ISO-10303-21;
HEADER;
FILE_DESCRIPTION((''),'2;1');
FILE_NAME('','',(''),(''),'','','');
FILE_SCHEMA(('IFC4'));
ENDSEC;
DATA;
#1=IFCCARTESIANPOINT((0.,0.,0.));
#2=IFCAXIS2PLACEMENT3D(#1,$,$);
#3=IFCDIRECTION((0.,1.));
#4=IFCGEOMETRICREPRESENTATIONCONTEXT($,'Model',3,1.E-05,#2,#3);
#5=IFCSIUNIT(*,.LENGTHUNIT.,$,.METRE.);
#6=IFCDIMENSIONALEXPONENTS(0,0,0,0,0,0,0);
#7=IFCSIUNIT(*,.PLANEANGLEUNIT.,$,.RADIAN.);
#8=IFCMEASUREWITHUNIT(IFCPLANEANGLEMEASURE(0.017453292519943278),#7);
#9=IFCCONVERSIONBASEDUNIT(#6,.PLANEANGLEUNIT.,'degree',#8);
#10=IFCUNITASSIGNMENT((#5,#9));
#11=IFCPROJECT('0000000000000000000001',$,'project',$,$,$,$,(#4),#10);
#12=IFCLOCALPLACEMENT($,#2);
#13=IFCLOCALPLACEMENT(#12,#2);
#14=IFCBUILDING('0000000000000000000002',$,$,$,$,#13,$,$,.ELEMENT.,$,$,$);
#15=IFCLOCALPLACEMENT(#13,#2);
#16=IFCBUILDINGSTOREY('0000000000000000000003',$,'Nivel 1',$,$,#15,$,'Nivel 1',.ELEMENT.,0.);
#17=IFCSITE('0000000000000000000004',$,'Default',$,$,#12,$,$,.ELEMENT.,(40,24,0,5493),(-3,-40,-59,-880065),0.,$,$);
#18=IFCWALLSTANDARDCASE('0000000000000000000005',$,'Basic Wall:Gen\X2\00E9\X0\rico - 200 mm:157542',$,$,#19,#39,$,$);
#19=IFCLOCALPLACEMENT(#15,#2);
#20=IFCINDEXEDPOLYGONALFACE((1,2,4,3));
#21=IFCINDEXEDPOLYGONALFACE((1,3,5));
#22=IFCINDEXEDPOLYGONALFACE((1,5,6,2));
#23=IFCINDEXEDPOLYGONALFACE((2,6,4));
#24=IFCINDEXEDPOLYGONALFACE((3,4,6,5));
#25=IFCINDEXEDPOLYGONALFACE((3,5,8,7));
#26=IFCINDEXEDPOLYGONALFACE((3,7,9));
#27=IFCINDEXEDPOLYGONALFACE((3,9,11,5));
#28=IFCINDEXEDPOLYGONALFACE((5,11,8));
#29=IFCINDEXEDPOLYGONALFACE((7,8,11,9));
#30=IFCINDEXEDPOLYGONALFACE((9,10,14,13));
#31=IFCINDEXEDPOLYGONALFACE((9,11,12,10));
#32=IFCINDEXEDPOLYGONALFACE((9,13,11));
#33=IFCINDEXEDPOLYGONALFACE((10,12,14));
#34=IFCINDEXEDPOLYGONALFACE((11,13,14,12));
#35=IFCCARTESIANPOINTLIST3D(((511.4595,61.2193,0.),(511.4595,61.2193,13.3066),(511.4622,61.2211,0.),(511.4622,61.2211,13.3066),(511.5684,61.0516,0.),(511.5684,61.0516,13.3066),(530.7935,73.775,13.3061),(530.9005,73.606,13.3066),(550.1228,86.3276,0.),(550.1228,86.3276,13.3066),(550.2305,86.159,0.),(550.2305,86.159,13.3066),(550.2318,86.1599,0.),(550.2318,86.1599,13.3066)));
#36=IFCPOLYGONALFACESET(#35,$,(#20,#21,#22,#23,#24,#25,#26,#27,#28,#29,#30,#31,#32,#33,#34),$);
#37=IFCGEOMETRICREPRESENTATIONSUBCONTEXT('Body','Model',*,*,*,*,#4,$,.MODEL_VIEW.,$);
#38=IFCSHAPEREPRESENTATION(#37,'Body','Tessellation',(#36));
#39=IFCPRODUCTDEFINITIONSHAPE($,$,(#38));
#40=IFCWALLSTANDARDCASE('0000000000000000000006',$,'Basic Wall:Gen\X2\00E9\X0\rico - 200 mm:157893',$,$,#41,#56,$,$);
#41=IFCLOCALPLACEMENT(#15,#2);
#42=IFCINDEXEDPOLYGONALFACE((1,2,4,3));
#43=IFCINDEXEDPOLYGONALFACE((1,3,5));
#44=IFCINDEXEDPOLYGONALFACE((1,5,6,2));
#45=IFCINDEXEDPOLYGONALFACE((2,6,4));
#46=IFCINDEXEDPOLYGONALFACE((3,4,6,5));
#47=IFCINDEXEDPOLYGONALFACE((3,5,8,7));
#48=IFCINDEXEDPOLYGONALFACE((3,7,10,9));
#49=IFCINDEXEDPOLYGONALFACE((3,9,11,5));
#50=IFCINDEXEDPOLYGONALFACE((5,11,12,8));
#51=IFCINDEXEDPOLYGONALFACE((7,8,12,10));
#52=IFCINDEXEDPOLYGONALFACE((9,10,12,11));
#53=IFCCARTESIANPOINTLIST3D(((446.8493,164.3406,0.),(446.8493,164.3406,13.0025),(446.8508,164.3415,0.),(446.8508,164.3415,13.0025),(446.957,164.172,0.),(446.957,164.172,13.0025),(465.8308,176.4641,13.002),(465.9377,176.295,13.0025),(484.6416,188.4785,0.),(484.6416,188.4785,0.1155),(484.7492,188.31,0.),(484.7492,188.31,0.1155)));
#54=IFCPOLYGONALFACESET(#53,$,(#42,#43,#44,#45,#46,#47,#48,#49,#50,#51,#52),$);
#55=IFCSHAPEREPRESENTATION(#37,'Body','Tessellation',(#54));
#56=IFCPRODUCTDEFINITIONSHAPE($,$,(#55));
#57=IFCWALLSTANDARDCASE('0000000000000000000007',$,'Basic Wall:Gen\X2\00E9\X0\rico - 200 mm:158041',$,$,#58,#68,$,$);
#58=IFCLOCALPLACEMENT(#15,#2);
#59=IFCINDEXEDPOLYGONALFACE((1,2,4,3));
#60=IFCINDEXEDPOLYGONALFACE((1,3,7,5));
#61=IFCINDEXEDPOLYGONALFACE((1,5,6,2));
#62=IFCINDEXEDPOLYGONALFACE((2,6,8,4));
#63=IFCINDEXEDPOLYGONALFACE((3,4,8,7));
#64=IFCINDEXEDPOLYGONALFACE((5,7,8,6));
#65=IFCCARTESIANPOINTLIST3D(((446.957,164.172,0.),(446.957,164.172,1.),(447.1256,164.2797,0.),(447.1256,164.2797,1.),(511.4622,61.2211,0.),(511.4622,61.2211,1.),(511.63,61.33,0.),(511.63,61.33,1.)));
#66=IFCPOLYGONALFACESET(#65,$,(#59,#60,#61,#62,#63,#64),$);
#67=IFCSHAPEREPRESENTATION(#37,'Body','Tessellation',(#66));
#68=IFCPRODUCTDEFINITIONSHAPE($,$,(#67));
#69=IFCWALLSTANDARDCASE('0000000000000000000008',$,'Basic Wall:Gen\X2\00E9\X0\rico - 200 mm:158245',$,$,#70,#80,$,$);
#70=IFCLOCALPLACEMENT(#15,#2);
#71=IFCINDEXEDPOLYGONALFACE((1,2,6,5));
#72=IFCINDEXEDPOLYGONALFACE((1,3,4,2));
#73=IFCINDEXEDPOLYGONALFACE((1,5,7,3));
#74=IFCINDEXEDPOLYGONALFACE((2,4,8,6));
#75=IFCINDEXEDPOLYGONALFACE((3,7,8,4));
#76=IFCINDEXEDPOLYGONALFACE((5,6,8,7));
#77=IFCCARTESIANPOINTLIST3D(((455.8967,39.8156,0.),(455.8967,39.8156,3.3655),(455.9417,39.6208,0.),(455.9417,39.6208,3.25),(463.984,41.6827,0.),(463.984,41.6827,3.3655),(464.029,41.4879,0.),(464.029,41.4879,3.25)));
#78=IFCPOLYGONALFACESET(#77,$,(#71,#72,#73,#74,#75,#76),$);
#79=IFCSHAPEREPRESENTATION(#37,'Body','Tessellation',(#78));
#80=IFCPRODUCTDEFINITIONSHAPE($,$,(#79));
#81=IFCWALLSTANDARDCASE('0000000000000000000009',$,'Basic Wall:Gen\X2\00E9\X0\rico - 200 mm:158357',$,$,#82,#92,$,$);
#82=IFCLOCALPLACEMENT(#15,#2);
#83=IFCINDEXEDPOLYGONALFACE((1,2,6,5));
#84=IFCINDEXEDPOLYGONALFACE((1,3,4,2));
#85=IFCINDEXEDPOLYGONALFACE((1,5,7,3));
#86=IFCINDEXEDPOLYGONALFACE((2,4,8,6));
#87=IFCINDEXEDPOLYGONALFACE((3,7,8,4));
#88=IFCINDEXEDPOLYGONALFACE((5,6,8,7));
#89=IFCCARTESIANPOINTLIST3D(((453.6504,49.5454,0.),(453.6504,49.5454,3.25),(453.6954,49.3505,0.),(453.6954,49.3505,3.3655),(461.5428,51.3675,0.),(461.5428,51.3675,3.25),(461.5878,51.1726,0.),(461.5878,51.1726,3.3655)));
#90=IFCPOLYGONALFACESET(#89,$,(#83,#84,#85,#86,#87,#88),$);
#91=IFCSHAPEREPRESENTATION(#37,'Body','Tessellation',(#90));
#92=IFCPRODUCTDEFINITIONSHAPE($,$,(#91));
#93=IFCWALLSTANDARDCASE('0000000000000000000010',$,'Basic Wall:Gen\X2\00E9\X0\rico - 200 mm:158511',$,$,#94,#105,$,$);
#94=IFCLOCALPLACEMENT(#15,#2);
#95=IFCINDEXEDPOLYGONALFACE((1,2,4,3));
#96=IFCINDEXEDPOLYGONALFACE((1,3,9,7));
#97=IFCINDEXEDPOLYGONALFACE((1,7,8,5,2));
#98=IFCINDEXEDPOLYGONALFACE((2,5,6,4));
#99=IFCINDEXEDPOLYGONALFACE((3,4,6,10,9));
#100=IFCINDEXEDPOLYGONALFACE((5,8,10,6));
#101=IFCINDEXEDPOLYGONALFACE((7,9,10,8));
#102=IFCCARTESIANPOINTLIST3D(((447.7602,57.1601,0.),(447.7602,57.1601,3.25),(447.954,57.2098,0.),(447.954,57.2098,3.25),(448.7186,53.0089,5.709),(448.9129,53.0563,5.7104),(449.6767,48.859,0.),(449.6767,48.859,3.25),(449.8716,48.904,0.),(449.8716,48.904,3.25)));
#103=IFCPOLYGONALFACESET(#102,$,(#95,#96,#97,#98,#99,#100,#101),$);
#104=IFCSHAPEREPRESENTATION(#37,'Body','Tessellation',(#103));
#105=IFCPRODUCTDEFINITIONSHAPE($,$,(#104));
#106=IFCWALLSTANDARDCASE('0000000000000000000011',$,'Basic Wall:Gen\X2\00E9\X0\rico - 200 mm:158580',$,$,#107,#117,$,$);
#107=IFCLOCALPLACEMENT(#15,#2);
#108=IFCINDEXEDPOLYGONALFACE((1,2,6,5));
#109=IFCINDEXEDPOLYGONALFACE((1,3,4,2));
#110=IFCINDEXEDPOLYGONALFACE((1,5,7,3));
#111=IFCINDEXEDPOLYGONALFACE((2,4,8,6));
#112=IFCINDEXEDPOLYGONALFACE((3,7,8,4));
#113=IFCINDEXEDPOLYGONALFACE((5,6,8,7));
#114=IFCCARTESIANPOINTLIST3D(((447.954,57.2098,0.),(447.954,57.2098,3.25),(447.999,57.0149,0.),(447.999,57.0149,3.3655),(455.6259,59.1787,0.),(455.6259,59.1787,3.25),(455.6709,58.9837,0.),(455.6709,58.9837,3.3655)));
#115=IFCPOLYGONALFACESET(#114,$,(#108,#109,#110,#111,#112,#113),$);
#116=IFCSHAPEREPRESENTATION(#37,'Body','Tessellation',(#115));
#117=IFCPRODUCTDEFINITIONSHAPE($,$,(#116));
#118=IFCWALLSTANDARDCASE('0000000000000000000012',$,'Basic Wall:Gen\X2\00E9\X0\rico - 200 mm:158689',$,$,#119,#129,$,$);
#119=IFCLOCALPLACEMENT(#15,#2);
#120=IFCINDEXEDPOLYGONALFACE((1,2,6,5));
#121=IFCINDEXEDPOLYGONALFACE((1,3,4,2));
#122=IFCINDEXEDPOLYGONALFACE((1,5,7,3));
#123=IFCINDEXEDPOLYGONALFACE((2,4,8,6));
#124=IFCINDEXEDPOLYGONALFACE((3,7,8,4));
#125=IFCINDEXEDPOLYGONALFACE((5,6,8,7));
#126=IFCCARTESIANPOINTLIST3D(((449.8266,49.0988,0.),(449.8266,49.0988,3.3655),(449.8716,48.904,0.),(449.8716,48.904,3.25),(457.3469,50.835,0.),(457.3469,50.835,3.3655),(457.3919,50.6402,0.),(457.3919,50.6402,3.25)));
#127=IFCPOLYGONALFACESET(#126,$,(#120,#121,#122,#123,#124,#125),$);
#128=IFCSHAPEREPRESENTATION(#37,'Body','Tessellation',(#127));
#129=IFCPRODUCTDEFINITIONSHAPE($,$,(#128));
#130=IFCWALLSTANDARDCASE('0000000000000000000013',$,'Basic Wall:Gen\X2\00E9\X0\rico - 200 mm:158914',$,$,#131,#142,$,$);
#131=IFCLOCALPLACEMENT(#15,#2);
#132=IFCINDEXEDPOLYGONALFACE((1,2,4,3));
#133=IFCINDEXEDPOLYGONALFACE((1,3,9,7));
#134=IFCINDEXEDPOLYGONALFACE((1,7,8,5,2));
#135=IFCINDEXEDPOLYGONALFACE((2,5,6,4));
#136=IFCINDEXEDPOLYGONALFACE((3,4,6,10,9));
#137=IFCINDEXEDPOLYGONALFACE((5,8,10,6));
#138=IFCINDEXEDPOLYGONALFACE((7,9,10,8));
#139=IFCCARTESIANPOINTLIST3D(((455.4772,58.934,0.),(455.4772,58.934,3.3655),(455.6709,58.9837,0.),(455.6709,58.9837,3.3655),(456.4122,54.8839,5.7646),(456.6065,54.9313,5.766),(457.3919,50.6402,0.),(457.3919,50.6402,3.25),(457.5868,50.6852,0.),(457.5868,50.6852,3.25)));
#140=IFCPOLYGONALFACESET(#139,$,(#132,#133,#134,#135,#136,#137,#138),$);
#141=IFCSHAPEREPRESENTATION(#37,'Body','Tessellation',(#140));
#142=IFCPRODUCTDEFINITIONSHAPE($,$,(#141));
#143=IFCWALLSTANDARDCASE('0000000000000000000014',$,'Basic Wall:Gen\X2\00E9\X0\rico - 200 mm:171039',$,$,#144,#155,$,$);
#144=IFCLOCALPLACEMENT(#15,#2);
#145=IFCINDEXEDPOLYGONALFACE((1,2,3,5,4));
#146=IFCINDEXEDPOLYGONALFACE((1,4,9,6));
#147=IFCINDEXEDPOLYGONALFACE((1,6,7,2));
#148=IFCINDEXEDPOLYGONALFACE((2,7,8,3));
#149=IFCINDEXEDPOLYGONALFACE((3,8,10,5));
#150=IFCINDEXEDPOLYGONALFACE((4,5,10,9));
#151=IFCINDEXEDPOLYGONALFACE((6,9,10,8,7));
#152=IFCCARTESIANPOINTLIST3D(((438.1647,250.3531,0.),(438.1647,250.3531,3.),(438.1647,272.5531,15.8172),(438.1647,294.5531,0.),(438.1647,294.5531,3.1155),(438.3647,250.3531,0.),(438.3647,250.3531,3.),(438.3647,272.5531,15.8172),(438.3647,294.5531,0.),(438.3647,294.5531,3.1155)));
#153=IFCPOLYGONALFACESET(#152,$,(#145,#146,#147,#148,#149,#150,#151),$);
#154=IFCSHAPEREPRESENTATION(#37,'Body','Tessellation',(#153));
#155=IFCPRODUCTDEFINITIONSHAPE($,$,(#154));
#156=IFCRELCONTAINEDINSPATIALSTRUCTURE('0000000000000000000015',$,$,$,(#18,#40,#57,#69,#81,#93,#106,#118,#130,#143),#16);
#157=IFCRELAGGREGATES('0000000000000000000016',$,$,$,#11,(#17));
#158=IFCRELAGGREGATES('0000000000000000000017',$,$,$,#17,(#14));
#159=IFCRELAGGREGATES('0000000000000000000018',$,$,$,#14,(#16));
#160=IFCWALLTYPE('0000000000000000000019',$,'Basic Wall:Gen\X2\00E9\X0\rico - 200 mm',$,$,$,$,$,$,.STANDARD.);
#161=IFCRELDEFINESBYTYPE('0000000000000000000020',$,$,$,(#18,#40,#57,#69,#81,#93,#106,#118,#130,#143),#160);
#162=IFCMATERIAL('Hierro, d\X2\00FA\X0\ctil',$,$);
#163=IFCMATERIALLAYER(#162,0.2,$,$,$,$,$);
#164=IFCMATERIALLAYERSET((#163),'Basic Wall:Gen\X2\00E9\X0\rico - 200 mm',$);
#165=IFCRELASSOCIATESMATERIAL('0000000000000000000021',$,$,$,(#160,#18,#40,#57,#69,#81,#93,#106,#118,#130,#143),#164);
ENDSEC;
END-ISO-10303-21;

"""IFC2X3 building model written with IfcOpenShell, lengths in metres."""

from ifc_helpers import new_model, entity, si_unit, converted_unit, direction, frame, frame_2d, origin, place, context, subcontext, project, spatial, polyline, rectangle, outline, extrude, clip, bounded_halfspace, material, layer, layer_set, layer_usage, type_object, element, save


model = new_model("IFC2X3")

# Units and contexts
model_context = context("Model", 3, precision=1e-05, world=origin(), true_north=direction((0.0, 1.0)))
body_context = subcontext(model_context, "Body", "Model", "MODEL_VIEW")
ifc_project = project(units=[si_unit("LENGTHUNIT", "METRE"), converted_unit("PLANEANGLEUNIT", "degree", entity("IfcPlaneAngleMeasure", 0.017453292519943278), si_unit("PLANEANGLEUNIT", "RADIAN"), dimensions=[0, 0, 0, 0, 0, 0, 0])], contexts=[model_context])

# Site, building, storey
site_placement = place(None, origin())
site = spatial("IfcSite", under=ifc_project, at=site_placement, Name="Default", CompositionType="ELEMENT", RefLatitude=(40, 24, 0, 5493), RefLongitude=(-3, -40, -59, -880065), RefElevation=0.0)
building_placement = place(site_placement, origin())
building = spatial("IfcBuilding", under=site, at=building_placement, CompositionType="ELEMENT")
storey_placement = place(building_placement, origin())
storey = spatial("IfcBuildingStorey", under=building, at=storey_placement, Name="Nivel 1", LongName="Nivel 1", CompositionType="ELEMENT", Elevation=0.0)

# Walls
ifc_material_1 = material(Name="Hierro, dúctil")
ifc_layer_1 = layer(ifc_material_1, 0.2)
ifc_layer_set_1 = layer_set([ifc_layer_1], Name="Basic Wall:Genérico - 200 mm")
ifc_layer_usage_1 = layer_usage(ifc_layer_set_1, "AXIS2", "NEGATIVE", 0.1)
wall_type = type_object("IfcWallType", Name="Basic Wall:Genérico - 200 mm", PredefinedType="STANDARD", material=ifc_layer_set_1)
wall_1_placement = place(storey_placement, frame((511.5139, 61.1354, 0.0), z_axis=(0.0, 0.0, 1.0), x_axis=(0.838671, 0.544639, 0.0)))
element("IfcWallStandardCase", 1, at=wall_1_placement, inside=storey, type_object=wall_type, material=ifc_layer_usage_1, Name="Basic Wall:Genérico - 200 mm:157542", context=body_context, shape_type="Clipping", body=[
    clip(clip(extrude(rectangle(XDim=46.1008, YDim=0.2, at=frame_2d((23.0504, 0.0), x_axis=(-1.0, 0.0))), origin(), (0.0, 0.0, 1.0), 13.3066), bounded_halfspace(frame((23.0508, -0.1, 13.3066), z_axis=(0.499986, -0.003784, 0.866025), x_axis=(0.007567, 0.999971, 0.0)), False, frame((23.0508, -0.1, 13.3066)), polyline([(0.0, 0.0), (23.0484, 0.0), (23.05, 0.2), (0.0024, 0.2), (0.0, 0.0)]))), bounded_halfspace(frame((0.0, -0.1, 0.0), z_axis=(-0.499934, 0.008118, 0.866025), x_axis=(-0.016236, -0.999868, 0.0)), False, frame((0.0, -0.1, 0.0)), polyline([(0.0, 0.0), (23.0508, 0.0), (23.0532, 0.2), (0.0032, 0.2), (0.0, 0.0)]))),
])
ifc_layer_usage_2 = layer_usage(ifc_layer_set_1, "AXIS2", "NEGATIVE", 0.1)
wall_2_placement = place(storey_placement, frame((484.6954, 188.3942, 0.0), z_axis=(0.0, 0.0, 1.0), x_axis=(-0.842768, -0.538277, 0.0)))
element("IfcWallStandardCase", 2, at=wall_2_placement, inside=storey, type_object=wall_type, material=ifc_layer_usage_2, Name="Basic Wall:Genérico - 200 mm:157893", context=body_context, shape_type="Clipping", body=[
    clip(clip(extrude(rectangle(XDim=44.843, YDim=0.2, at=frame_2d((22.4215, 0.0), x_axis=(-1.0, 0.0))), origin(), (0.0, 0.0, 1.0), 13.0025), bounded_halfspace(frame((0.0, -0.1, 0.1155), z_axis=(-0.5, 0.0, 0.866025), x_axis=(0.0, -1.0, 0.0)), False, frame((0.0, -0.1, 0.1155)), polyline([(0.0, 0.0), (22.3202, 0.0), (22.3211, 0.2), (0.0, 0.2), (0.0, 0.0)]))), bounded_halfspace(frame((22.3202, -0.1, 13.002), z_axis=(0.499981, -0.004335, 0.866025), x_axis=(0.008669, 0.999962, 0.0)), False, frame((22.3202, -0.1, 13.002)), polyline([(0.0, 0.0), (22.5211, 0.0), (22.5228, 0.2), (0.0009, 0.2), (0.0, 0.0)]))),
])
ifc_layer_usage_3 = layer_usage(ifc_layer_set_1, "AXIS2", "NEGATIVE", 0.1)
wall_3_placement = place(storey_placement, frame((447.0408, 164.2266, 0.0), z_axis=(0.0, 0.0, 1.0), x_axis=(0.530951, -0.847403, 0.0)))
element("IfcWallStandardCase", 3, at=wall_3_placement, inside=storey, type_object=wall_type, material=ifc_layer_usage_3, Name="Basic Wall:Genérico - 200 mm:158041", context=body_context, shape_type="SweptSolid", body=[
    extrude(outline(polyline([(121.4917, -0.1), (121.4885, 0.1), (0.0, 0.1), (0.0017, -0.1), (121.4917, -0.1)])), origin(), (0.0, 0.0, 1.0), 1.0),
])
ifc_layer_usage_4 = layer_usage(ifc_layer_set_1, "AXIS2", "NEGATIVE", 0.1)
wall_4_placement = place(storey_placement, frame((455.9192, 39.7182, 0.0), z_axis=(0.0, 0.0, 1.0), x_axis=(0.97437, 0.224951, 0.0)))
element("IfcWallStandardCase", 4, at=wall_4_placement, inside=storey, type_object=wall_type, material=ifc_layer_usage_4, Name="Basic Wall:Genérico - 200 mm:158245", context=body_context, shape_type="Clipping", body=[
    clip(extrude(rectangle(XDim=8.3, YDim=0.2, at=frame_2d((4.15, 0.0), x_axis=(-1.0, 0.0))), origin(), (0.0, 0.0, 1.0), 3.3655), bounded_halfspace(frame((0.0, -0.1, 3.25), z_axis=(0.0, -0.5, 0.866025), x_axis=(1.0, 0.0, 0.0)), False, frame((0.0, -0.1, 3.25)), polyline([(0.0, 0.0), (8.3, 0.0), (8.3, 0.2), (8.1, 0.2), (0.2, 0.2), (0.0, 0.2), (0.0, 0.0)]))),
])
ifc_layer_usage_5 = layer_usage(ifc_layer_set_1, "AXIS2", "NEGATIVE", 0.1)
wall_5_placement = place(storey_placement, frame((461.5653, 51.27, 0.0), z_axis=(0.0, 0.0, 1.0), x_axis=(-0.97437, -0.224951, 0.0)))
element("IfcWallStandardCase", 5, at=wall_5_placement, inside=storey, type_object=wall_type, material=ifc_layer_usage_5, Name="Basic Wall:Genérico - 200 mm:158357", context=body_context, shape_type="Clipping", body=[
    clip(extrude(rectangle(XDim=8.1, YDim=0.2, at=frame_2d((4.05, 0.0), x_axis=(-1.0, 0.0))), origin(), (0.0, 0.0, 1.0), 3.3655), bounded_halfspace(frame((0.0, -0.1, 3.25), z_axis=(0.0, -0.5, 0.866025), x_axis=(1.0, 0.0, 0.0)), False, frame((0.0, -0.1, 3.25)), polyline([(0.0, 0.0), (8.1, 0.0), (8.1, 0.2), (7.9, 0.2), (0.0, 0.2), (0.0, 0.0)]))),
])
ifc_layer_usage_6 = layer_usage(ifc_layer_set_1, "AXIS2", "NEGATIVE", 0.1)
wall_6_placement = place(storey_placement, frame((449.7741, 48.8815, 0.0), z_axis=(0.0, 0.0, 1.0), x_axis=(-0.224951, 0.97437, 0.0)))
element("IfcWallStandardCase", 6, at=wall_6_placement, inside=storey, type_object=wall_type, material=ifc_layer_usage_6, Name="Basic Wall:Genérico - 200 mm:158511", context=body_context, shape_type="Clipping", body=[
    clip(clip(extrude(outline(polyline([(8.5243, -0.1), (8.5194, 0.1), (0.0, 0.1), (0.0, -0.1), (0.2, -0.1), (8.3243, -0.1), (8.5243, -0.1)])), origin(), (0.0, 0.0, 1.0), 5.7104), bounded_halfspace(frame((4.2615, -0.1, 5.7104), z_axis=(0.499852, 0.01216, 0.866025), x_axis=(-0.024319, 0.999704, 0.0)), False, frame((4.2615, -0.1, 5.7104)), polyline([(0.0, 0.0), (4.0627, 0.0), (4.2628, 0.0), (4.2579, 0.2), (-0.0024, 0.2), (0.0, 0.0)]))), bounded_halfspace(frame((0.0, -0.1, 3.25), z_axis=(-0.5, 0.0, 0.866025), x_axis=(0.0, -1.0, 0.0)), False, frame((0.0, -0.1, 3.25)), polyline([(0.0, 0.0), (0.2, 0.0), (4.2615, 0.0), (4.2591, 0.2), (0.0, 0.2), (0.0, 0.0)]))),
])
ifc_layer_usage_7 = layer_usage(ifc_layer_set_1, "AXIS2", "NEGATIVE", 0.1)
wall_7_placement = place(storey_placement, frame((447.9741, 57.1117, 0.0), z_axis=(0.0, 0.0, 1.0), x_axis=(0.968611, 0.248581, 0.0)))
element("IfcWallStandardCase", 7, at=wall_7_placement, inside=storey, type_object=wall_type, material=ifc_layer_usage_7, Name="Basic Wall:Genérico - 200 mm:158580", context=body_context, shape_type="Clipping", body=[
    clip(extrude(outline(polyline([(7.9205, -0.1), (7.9254, 0.1), (0.0049, 0.1), (0.0, -0.1), (7.7205, -0.1), (7.9205, -0.1)])), origin(), (0.0, 0.0, 1.0), 3.3655), bounded_halfspace(frame((0.0, -0.1, 3.3655), z_axis=(0.0, 0.5, 0.866025), x_axis=(-1.0, 0.0, 0.0)), False, frame((0.0, -0.1, 3.3655)), polyline([(0.0, 0.0), (7.7205, 0.0), (7.9205, 0.0), (7.9254, 0.2), (0.0049, 0.2), (0.0, 0.0)]))),
])
ifc_layer_usage_8 = layer_usage(ifc_layer_set_1, "AXIS2", "NEGATIVE", 0.1)
wall_8_placement = place(storey_placement, frame((449.8491, 49.0014, 0.0), z_axis=(0.0, 0.0, 1.0), x_axis=(0.97437, 0.224951, 0.0)))
element("IfcWallStandardCase", 8, at=wall_8_placement, inside=storey, type_object=wall_type, material=ifc_layer_usage_8, Name="Basic Wall:Genérico - 200 mm:158689", context=body_context, shape_type="Clipping", body=[
    clip(extrude(rectangle(XDim=7.7182, YDim=0.2, at=frame_2d((3.8591, 0.0), x_axis=(-1.0, 0.0))), origin(), (0.0, 0.0, 1.0), 3.3655), bounded_halfspace(frame((0.0, -0.1, 3.25), z_axis=(0.0, -0.5, 0.866025), x_axis=(1.0, 0.0, 0.0)), False, frame((0.0, -0.1, 3.25)), polyline([(0.0, 0.0), (7.7182, 0.0), (7.7182, 0.2), (0.0, 0.2), (0.0, 0.0)]))),
])
ifc_layer_usage_9 = layer_usage(ifc_layer_set_1, "AXIS2", "NEGATIVE", 0.1)
wall_9_placement = place(storey_placement, frame((457.4894, 50.6627, 0.0), z_axis=(0.0, 0.0, 1.0), x_axis=(-0.224951, 0.97437, 0.0)))
element("IfcWallStandardCase", 9, at=wall_9_placement, inside=storey, type_object=wall_type, material=ifc_layer_usage_9, Name="Basic Wall:Genérico - 200 mm:158914", context=body_context, shape_type="Clipping", body=[
    clip(clip(extrude(outline(polyline([(8.5169, -0.1), (8.512, 0.1), (0.2, 0.1), (0.0, 0.1), (0.0, -0.1), (8.5169, -0.1)])), origin(), (0.0, 0.0, 1.0), 5.766), bounded_halfspace(frame((4.3578, -0.1, 5.766), z_axis=(0.499852, 0.01216, 0.866025), x_axis=(-0.024319, 0.999704, 0.0)), False, frame((4.3578, -0.1, 5.766)), polyline([(0.0, 0.0), (4.1591, 0.0), (4.1542, 0.2), (-0.0024, 0.2), (0.0, 0.0)]))), bounded_halfspace(frame((0.0, -0.1, 3.25), z_axis=(-0.5, 0.0, 0.866025), x_axis=(0.0, -1.0, 0.0)), False, frame((0.0, -0.1, 3.25)), polyline([(0.0, 0.0), (4.3578, 0.0), (4.3554, 0.2), (0.2, 0.2), (0.0, 0.2), (0.0, 0.0)]))),
])
ifc_layer_usage_10 = layer_usage(ifc_layer_set_1, "AXIS2", "NEGATIVE", 0.1)
wall_10_placement = place(storey_placement, frame((438.2647, 294.5531, 0.0), z_axis=(0.0, 0.0, 1.0), x_axis=(0.0, -1.0, 0.0)))
element("IfcWallStandardCase", 10, at=wall_10_placement, inside=storey, type_object=wall_type, material=ifc_layer_usage_10, Name="Basic Wall:Genérico - 200 mm:171039", context=body_context, shape_type="Clipping", body=[
    clip(clip(extrude(rectangle(XDim=44.2, YDim=0.2, at=frame_2d((22.1, 0.0), x_axis=(-1.0, 0.0))), origin(), (0.0, 0.0, 1.0), 15.8172), bounded_halfspace(frame((0.0, -0.1, 3.1155), z_axis=(-0.5, 0.0, 0.866025), x_axis=(0.0, -1.0, 0.0)), False, frame((0.0, -0.1, 3.1155)), polyline([(0.0, 0.0), (22.0, 0.0), (22.0, 0.2), (0.0, 0.2), (0.0, 0.0)]))), bounded_halfspace(frame((22.0, -0.1, 15.8172), z_axis=(0.5, 0.0, 0.866025), x_axis=(0.0, 1.0, 0.0)), False, frame((22.0, -0.1, 15.8172)), polyline([(0.0, 0.0), (22.0, 0.0), (22.2, 0.0), (22.2, 0.2), (0.0, 0.2), (0.0, 0.0)]))),
])

save(model, "model.ifc")
